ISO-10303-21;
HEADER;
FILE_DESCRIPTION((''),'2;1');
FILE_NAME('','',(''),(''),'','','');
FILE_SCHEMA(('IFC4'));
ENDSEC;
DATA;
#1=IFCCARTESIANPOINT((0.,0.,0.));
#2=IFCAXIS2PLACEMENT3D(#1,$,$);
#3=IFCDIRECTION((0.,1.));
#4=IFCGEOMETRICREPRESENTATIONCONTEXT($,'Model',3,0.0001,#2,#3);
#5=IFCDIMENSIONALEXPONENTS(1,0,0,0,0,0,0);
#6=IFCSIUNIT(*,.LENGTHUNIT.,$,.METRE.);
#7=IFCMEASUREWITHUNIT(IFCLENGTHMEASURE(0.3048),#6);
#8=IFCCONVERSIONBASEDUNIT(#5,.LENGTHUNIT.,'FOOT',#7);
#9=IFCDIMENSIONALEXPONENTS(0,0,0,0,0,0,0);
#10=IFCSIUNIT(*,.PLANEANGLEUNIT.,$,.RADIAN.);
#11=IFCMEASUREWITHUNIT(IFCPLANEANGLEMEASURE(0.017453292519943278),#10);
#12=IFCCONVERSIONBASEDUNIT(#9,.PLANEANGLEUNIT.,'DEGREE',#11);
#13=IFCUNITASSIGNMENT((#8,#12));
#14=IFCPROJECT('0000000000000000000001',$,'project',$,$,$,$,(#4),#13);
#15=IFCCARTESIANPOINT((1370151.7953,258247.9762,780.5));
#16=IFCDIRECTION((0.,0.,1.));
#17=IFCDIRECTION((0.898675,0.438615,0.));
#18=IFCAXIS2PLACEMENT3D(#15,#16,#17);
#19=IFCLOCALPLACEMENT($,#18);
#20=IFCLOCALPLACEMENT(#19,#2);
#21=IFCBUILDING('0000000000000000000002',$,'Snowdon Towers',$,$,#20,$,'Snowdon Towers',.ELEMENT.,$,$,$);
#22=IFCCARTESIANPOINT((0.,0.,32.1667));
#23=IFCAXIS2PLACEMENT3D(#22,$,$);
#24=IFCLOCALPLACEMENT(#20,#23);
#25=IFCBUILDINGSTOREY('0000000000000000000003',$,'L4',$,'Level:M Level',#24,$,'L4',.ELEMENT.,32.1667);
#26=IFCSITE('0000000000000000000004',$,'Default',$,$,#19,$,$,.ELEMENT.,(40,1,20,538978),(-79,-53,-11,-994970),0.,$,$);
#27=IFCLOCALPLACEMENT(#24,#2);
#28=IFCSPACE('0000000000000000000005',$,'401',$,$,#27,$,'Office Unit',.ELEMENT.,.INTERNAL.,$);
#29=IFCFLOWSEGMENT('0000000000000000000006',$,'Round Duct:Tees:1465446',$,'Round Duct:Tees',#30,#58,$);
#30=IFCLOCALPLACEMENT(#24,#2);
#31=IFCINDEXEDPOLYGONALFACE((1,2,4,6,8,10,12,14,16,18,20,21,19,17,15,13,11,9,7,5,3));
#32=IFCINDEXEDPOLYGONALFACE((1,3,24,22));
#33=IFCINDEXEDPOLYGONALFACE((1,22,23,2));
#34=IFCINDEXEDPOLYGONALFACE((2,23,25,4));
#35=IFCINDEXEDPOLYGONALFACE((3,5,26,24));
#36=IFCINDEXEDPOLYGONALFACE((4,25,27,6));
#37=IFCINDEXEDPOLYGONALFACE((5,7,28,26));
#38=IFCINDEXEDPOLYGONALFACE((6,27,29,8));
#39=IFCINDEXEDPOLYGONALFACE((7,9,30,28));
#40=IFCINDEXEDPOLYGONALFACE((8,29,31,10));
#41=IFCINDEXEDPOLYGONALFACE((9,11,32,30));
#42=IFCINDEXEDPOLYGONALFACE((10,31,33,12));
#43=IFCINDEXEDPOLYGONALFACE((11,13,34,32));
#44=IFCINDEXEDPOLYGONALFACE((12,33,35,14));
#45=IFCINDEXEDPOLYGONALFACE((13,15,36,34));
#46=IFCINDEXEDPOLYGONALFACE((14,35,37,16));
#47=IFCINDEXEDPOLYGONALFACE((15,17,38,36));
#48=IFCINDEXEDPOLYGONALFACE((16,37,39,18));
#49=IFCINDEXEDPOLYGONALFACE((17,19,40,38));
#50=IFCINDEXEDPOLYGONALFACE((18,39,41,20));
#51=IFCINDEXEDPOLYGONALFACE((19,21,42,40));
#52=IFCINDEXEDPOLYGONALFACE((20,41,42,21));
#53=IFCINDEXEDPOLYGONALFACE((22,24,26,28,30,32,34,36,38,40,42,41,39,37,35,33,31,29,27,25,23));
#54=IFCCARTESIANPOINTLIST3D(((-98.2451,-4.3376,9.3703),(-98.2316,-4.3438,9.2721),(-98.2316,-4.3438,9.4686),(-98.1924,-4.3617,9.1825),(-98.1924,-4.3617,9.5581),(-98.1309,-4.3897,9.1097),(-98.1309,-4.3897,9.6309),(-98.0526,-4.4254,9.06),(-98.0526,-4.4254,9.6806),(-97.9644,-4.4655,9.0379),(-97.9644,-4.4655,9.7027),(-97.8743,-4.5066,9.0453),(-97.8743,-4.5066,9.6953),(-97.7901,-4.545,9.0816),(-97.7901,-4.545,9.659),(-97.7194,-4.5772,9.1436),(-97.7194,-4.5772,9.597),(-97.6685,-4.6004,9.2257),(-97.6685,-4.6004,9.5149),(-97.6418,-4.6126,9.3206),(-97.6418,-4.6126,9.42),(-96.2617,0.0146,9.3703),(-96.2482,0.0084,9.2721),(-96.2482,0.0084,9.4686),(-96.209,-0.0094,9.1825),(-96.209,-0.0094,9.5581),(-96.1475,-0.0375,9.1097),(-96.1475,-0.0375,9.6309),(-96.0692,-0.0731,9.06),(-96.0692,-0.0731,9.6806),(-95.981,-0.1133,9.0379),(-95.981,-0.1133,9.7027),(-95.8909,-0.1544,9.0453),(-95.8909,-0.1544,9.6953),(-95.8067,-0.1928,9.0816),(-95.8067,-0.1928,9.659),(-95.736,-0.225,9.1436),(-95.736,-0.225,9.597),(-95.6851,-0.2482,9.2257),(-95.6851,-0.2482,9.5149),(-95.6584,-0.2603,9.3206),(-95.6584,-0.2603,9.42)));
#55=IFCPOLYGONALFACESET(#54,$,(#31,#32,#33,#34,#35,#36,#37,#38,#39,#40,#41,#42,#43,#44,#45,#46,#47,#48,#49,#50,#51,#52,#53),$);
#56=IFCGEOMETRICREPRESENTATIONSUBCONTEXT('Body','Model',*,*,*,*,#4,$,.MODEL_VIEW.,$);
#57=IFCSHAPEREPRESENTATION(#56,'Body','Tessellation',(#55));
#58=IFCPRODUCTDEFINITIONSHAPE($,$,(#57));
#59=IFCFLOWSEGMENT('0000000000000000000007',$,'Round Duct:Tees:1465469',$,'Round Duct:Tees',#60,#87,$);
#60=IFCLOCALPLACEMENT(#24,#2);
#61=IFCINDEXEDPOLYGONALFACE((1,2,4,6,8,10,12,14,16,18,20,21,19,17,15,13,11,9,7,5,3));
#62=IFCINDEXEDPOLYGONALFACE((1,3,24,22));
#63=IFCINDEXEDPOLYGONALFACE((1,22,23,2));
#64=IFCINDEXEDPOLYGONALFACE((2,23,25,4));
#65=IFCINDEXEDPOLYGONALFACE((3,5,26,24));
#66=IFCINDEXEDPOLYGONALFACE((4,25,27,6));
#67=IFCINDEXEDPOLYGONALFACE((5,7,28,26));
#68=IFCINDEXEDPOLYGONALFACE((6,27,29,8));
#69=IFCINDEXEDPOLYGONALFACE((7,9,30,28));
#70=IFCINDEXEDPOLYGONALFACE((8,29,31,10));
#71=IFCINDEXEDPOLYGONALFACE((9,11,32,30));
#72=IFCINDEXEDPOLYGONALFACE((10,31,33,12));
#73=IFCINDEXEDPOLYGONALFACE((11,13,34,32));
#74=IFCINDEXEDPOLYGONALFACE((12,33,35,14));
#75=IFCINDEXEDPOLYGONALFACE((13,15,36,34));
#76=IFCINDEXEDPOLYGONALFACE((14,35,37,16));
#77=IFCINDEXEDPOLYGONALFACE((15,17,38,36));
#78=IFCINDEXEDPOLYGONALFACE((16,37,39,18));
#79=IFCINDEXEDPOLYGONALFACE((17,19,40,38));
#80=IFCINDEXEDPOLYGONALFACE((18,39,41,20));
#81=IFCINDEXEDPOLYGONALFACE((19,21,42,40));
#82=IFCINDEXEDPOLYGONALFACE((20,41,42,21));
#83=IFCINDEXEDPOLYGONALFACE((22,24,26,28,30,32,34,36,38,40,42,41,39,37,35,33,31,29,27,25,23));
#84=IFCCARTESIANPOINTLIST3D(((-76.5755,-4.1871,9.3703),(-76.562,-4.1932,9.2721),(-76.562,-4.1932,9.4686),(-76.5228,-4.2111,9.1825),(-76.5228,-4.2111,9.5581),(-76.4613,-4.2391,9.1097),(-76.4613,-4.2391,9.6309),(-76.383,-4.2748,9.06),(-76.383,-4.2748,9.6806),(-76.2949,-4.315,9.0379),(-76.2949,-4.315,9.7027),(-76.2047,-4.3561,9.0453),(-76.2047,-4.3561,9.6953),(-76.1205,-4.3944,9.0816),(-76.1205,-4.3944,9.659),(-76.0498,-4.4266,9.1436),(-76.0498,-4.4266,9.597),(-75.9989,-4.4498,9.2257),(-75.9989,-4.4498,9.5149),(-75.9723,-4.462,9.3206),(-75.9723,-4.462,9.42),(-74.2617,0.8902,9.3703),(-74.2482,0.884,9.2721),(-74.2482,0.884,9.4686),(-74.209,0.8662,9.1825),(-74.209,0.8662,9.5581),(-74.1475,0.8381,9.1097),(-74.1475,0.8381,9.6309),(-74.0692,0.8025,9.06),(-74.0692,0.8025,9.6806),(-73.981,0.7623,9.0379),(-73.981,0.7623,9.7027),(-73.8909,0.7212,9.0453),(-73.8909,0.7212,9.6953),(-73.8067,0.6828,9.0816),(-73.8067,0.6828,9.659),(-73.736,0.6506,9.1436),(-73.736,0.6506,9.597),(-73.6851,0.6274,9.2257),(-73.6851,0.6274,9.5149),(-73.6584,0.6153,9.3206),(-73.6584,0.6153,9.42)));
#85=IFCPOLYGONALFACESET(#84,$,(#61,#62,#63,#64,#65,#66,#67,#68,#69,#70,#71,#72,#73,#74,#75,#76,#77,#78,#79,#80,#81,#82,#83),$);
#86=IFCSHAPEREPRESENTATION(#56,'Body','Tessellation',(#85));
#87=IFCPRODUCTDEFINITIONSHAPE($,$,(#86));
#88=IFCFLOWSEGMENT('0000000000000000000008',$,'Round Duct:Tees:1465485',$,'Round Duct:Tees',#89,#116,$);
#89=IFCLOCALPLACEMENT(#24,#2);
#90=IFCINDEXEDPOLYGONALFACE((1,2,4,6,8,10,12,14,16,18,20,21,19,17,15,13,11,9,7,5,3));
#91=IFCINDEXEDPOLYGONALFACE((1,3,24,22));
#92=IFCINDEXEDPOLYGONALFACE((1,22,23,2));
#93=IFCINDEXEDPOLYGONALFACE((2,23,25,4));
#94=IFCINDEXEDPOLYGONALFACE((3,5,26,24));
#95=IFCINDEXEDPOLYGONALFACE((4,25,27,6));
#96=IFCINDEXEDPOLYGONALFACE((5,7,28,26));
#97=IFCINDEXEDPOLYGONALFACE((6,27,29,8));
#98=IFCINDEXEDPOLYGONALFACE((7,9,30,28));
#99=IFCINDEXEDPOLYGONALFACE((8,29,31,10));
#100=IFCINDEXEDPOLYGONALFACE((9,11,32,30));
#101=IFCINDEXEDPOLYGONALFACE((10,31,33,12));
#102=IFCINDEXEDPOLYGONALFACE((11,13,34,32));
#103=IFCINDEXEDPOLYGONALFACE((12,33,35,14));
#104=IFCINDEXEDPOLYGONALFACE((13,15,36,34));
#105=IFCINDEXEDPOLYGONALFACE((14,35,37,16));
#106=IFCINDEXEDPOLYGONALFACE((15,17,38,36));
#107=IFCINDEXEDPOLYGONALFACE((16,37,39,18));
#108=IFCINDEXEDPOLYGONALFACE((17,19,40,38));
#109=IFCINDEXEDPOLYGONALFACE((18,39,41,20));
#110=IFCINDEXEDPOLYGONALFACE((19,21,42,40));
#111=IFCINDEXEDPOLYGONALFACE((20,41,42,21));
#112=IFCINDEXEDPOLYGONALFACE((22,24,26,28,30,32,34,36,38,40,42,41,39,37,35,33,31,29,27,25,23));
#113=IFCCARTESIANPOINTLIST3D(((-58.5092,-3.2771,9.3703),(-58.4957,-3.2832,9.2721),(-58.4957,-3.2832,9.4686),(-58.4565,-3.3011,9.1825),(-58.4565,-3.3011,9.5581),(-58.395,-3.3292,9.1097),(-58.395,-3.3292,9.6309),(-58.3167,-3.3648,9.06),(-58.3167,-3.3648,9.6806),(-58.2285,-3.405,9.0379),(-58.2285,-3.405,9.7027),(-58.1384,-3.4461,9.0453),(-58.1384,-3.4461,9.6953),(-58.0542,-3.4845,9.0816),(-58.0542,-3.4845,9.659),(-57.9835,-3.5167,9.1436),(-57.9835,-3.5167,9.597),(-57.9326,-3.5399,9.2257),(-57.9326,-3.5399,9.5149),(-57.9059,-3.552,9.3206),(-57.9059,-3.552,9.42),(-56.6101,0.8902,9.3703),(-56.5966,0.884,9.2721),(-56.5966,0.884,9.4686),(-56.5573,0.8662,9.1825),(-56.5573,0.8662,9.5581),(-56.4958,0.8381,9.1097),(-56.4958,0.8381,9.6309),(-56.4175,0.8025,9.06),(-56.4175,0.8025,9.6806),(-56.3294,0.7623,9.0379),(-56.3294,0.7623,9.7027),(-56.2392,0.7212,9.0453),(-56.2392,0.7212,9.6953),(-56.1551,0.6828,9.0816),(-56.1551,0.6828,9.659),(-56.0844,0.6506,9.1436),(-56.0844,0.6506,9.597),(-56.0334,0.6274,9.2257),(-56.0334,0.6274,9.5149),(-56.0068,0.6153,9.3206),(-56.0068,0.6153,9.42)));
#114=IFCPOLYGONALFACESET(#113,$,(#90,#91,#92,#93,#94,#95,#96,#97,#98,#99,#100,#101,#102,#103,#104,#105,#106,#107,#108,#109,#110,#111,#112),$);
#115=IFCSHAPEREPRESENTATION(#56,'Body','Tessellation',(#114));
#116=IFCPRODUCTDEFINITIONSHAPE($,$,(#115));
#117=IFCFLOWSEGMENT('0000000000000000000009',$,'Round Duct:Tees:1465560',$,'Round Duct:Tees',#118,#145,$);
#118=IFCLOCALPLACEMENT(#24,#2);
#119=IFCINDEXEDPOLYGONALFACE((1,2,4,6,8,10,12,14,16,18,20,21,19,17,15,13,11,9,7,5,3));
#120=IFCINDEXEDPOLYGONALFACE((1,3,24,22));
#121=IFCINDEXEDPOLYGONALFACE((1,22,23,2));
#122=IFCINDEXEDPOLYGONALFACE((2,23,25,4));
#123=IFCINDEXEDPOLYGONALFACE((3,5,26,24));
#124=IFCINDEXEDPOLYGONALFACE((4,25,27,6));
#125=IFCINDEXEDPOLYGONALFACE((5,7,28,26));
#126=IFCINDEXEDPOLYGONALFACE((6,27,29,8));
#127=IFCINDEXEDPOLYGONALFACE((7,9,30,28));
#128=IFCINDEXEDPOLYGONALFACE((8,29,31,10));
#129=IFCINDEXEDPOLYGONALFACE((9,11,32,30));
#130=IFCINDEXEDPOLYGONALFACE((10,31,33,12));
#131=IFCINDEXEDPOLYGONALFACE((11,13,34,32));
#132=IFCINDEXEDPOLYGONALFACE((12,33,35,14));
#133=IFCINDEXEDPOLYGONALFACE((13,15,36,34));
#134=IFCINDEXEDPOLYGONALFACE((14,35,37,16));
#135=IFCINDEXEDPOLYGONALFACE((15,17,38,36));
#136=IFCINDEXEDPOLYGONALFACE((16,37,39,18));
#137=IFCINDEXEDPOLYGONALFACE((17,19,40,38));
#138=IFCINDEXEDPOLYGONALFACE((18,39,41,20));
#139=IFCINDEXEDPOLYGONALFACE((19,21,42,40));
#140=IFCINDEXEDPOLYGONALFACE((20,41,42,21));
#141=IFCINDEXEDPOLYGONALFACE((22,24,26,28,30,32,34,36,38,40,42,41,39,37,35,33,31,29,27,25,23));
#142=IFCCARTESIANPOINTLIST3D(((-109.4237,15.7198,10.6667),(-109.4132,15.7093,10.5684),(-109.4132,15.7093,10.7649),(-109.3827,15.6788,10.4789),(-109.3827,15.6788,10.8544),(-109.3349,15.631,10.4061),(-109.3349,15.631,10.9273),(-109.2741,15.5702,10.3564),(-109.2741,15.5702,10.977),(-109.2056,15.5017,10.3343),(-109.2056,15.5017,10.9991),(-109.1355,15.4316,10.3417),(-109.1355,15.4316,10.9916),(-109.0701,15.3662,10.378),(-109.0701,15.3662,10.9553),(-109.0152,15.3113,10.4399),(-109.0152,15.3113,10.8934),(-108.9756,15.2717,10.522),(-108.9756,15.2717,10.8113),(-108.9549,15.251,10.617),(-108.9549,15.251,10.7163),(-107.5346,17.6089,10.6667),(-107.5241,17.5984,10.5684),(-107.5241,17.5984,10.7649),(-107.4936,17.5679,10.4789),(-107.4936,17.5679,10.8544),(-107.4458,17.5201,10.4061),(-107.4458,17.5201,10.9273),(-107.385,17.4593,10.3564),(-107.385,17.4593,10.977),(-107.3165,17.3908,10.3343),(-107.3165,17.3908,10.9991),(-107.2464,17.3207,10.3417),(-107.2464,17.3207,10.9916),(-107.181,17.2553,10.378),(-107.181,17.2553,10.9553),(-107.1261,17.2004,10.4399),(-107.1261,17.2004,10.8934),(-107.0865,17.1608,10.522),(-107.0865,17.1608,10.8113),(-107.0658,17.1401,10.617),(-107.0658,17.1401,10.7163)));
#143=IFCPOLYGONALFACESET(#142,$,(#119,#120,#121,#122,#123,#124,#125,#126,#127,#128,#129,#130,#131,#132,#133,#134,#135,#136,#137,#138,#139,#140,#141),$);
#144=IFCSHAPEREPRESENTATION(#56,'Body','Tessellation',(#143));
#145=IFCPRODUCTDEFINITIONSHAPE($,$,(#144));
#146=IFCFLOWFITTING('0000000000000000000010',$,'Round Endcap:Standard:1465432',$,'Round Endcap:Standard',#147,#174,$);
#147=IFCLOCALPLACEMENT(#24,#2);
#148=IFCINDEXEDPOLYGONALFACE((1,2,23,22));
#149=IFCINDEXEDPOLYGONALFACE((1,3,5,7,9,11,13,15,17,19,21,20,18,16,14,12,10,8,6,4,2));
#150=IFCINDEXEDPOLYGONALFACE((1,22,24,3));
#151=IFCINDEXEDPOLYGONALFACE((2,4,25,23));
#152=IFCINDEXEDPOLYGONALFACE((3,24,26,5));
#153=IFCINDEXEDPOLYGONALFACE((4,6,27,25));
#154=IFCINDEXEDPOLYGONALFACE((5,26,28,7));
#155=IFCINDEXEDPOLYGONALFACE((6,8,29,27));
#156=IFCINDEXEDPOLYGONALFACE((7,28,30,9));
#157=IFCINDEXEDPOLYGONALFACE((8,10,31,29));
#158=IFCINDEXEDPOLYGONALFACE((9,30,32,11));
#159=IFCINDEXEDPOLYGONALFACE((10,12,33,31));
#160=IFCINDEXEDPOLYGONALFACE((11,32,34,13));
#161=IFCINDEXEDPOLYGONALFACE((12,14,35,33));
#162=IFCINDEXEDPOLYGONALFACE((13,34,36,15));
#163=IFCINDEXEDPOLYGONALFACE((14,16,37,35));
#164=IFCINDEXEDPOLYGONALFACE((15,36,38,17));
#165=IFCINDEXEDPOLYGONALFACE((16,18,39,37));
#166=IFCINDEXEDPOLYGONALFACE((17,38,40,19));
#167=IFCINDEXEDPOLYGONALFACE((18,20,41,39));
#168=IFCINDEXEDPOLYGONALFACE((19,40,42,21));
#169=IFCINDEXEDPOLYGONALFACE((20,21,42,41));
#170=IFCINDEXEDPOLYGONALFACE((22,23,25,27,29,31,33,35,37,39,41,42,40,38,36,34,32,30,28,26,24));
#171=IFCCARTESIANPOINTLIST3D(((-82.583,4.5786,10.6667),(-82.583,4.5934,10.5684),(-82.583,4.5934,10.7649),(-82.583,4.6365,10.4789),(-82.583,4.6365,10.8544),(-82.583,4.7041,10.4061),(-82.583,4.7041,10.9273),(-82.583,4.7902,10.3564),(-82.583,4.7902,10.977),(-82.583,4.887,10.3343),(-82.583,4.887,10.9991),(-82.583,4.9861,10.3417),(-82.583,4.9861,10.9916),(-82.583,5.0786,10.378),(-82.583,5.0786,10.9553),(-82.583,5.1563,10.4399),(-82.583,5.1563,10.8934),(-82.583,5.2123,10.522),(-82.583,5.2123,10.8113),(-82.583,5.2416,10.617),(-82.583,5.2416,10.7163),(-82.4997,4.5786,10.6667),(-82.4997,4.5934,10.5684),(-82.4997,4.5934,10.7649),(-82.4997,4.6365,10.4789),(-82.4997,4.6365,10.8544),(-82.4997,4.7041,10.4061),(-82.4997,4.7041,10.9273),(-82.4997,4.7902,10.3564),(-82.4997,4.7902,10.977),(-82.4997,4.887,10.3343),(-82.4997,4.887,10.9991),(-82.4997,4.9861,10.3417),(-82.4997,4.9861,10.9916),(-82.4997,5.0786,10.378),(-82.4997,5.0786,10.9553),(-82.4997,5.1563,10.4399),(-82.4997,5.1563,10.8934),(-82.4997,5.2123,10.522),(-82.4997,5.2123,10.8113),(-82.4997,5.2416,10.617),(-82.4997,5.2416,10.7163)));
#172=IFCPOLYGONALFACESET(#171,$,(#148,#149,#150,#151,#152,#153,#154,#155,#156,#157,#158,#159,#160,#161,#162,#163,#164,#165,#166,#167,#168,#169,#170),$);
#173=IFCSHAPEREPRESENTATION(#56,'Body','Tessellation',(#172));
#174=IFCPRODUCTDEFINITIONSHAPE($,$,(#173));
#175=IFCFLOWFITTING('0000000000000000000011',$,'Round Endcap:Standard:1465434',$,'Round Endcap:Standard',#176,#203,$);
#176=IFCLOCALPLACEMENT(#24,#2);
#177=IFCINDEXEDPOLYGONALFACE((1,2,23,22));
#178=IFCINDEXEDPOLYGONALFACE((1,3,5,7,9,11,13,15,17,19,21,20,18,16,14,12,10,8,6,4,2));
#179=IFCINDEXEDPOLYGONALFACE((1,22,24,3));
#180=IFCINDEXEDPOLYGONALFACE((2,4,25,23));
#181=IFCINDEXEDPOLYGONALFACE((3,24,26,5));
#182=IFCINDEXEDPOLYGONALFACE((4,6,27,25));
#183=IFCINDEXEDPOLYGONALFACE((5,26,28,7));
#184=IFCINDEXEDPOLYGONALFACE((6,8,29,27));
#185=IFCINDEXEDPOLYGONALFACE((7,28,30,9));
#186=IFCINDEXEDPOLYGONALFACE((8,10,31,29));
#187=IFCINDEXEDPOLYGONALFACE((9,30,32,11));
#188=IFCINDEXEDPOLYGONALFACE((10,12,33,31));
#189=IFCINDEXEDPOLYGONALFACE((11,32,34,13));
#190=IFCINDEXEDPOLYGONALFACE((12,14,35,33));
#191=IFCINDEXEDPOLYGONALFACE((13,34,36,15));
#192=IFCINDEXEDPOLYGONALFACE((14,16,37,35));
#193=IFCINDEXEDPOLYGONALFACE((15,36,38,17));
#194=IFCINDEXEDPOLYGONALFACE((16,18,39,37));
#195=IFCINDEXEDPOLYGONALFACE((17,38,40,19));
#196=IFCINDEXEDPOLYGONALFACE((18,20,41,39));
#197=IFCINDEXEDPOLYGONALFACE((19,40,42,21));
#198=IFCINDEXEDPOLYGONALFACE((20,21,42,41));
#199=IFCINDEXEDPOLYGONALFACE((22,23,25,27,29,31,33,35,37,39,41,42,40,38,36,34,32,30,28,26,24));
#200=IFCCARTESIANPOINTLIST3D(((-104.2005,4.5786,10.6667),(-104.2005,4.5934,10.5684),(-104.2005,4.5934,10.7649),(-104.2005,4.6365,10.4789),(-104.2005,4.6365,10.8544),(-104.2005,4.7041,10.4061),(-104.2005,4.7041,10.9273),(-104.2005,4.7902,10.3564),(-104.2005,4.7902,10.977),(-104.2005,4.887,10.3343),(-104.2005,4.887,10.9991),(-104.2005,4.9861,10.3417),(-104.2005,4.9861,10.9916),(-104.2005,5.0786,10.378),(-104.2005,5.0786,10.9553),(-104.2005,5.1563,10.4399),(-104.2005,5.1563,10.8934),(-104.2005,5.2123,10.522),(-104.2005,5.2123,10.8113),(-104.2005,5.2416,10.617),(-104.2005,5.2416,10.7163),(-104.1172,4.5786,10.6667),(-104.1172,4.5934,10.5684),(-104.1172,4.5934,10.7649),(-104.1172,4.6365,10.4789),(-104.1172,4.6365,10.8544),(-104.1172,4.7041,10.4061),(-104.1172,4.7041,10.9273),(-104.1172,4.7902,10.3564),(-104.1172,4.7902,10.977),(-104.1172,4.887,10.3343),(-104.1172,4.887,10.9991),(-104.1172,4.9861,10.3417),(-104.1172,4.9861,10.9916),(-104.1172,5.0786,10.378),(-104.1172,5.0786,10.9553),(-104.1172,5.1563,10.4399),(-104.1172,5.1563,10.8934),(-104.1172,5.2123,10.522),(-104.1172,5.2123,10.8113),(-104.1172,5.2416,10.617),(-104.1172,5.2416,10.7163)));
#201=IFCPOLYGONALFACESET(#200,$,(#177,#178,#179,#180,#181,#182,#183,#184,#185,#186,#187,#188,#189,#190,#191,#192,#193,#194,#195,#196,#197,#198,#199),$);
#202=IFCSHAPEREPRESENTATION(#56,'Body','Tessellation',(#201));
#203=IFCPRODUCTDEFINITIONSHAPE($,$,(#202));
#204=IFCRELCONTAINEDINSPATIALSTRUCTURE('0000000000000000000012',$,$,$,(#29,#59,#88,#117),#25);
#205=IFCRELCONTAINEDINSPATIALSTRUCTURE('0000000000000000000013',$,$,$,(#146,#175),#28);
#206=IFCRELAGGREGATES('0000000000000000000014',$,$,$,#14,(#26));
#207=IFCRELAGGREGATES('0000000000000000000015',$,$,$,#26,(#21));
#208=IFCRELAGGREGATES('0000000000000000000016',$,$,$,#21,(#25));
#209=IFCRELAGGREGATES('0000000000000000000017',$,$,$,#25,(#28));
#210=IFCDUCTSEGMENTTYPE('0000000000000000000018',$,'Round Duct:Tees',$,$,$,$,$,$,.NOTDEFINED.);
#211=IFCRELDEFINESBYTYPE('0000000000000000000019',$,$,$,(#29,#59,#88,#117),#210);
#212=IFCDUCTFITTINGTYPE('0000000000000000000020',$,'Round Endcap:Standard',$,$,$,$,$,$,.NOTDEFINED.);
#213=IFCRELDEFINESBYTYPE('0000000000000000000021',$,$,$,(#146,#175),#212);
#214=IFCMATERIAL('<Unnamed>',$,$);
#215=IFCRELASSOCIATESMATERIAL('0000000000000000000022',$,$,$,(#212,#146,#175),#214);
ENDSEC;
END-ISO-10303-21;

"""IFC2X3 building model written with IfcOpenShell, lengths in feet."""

from ifc_helpers import new_model, entity, si_unit, converted_unit, direction, frame, frame_2d, origin, origin_2d_with_axis, place, context, subcontext, project, spatial, circle, extrude, source, transform, mapped, material, type_object, type_shapes, element, save


model = new_model("IFC2X3")

# Units and contexts
model_context = context("Model", 3, precision=0.0001, world=origin(), true_north=direction((0.0, 1.0)))
body_context = subcontext(model_context, "Body", "Model", "MODEL_VIEW")
ifc_project = project(units=[converted_unit("LENGTHUNIT", "FOOT", entity("IfcLengthMeasure", 0.3048), si_unit("LENGTHUNIT", "METRE"), dimensions=[1, 0, 0, 0, 0, 0, 0]), converted_unit("PLANEANGLEUNIT", "DEGREE", entity("IfcPlaneAngleMeasure", 0.017453292519943278), si_unit("PLANEANGLEUNIT", "RADIAN"), dimensions=[0, 0, 0, 0, 0, 0, 0])], contexts=[model_context])

# Site, building, storey
site_placement = place(None, frame((1370151.7953, 258247.9762, 780.5), z_axis=(0.0, 0.0, 1.0), x_axis=(0.898675, 0.438615, 0.0)))
site = spatial("IfcSite", under=ifc_project, at=site_placement, Name="Default", CompositionType="ELEMENT", RefLatitude=(40, 1, 20, 538978), RefLongitude=(-79, -53, -11, -994970), RefElevation=0.0)
building_placement = place(site_placement, origin())
building = spatial("IfcBuilding", under=site, at=building_placement, Name="Snowdon Towers", LongName="Snowdon Towers", CompositionType="ELEMENT")
storey_placement = place(building_placement, frame((0.0, 0.0, 32.1667)))
storey = spatial("IfcBuildingStorey", under=building, at=storey_placement, Name="L4", ObjectType="Level:M Level", LongName="L4", CompositionType="ELEMENT", Elevation=32.1667)

# Flow segments
duct_segment_type = type_object("IfcDuctSegmentType", Name="Round Duct:Tees", PredefinedType="NOTDEFINED")
flow_segment_1_placement = place(storey_placement, frame((-98.2503, -4.6193, 9.7089)))
element("IfcFlowSegment", 1, at=flow_segment_1_placement, inside=storey, type_object=duct_segment_type, Name="Round Duct:Tees:1465446", ObjectType="Round Duct:Tees", context=body_context, shape_type="SweptSolid", body=[
    extrude(circle(Radius=0.3333, at=origin_2d_with_axis()), frame((0.3086, 0.1435, -0.3386), z_axis=(0.414693, 0.909961, 0.0), x_axis=(-0.909961, 0.414693, 0.0)), (0.0, 0.0, 1.0), 4.7829),
])
flow_segment_2_placement = place(storey_placement, frame((-76.5807, -4.4688, 9.7089)))
element("IfcFlowSegment", 2, at=flow_segment_2_placement, inside=storey, type_object=duct_segment_type, Name="Round Duct:Tees:1465469", ObjectType="Round Duct:Tees", context=body_context, shape_type="SweptSolid", body=[
    extrude(circle(Radius=0.3333, at=frame_2d((0.0, 0.0), x_axis=(1.0, 0.0))), frame((0.3086, 0.1435, -0.3386), z_axis=(0.414693, 0.909961, 0.0), x_axis=(-0.909961, 0.414693, 0.0)), (0.0, 0.0, 1.0), 5.5796),
])
flow_segment_3_placement = place(storey_placement, frame((-58.5144, -3.5588, 9.0317)))
element("IfcFlowSegment", 3, at=flow_segment_3_placement, inside=storey, type_object=duct_segment_type, Name="Round Duct:Tees:1465485", ObjectType="Round Duct:Tees", context=body_context, shape_type="SweptSolid", body=[
    extrude(circle(Radius=0.3333, at=origin_2d_with_axis()), frame((0.3086, 0.1435, 0.3386), z_axis=(0.414693, 0.909961, 0.0), x_axis=(-0.909961, 0.414693, 0.0)), (0.0, 0.0, 1.0), 4.5796),
])
flow_segment_4_placement = place(storey_placement, frame((-109.4289, 15.2431, 10.3281)))
element("IfcFlowSegment", 4, at=flow_segment_4_placement, inside=storey, type_object=duct_segment_type, Name="Round Duct:Tees:1465560", ObjectType="Round Duct:Tees", context=body_context, shape_type="SweptSolid", body=[
    extrude(circle(Radius=0.3333, at=frame_2d((0.0, 0.0), x_axis=(1.0, 0.0))), frame((0.2409, 0.2409, 0.3386), z_axis=(0.707107, 0.707107, 0.0), x_axis=(-0.707107, 0.707107, 0.0)), (0.0, 0.0, 1.0), 2.6716),
])

# Shared definitions
space_placement = place(storey_placement, origin())
space = spatial("IfcSpace", under=storey, at=space_placement, Name="401", LongName="Office Unit", CompositionType="ELEMENT", InteriorOrExteriorSpace="INTERNAL")

# Flow fittings
ifc_material = material(Name="<Unnamed>")
duct_fitting_type = type_object("IfcDuctFittingType", Name="Round Endcap:Standard", PredefinedType="NOTDEFINED", material=ifc_material)
shared_shape = source(origin(), body_context, "Body", "SweptSolid", [
    extrude(circle(Radius=0.3333, at=frame_2d((0.0, 0.0), x_axis=(1.0, 0.0))), frame((0.0, 0.0, 0.0), z_axis=(1.0, 0.0, 0.0), x_axis=(0.0, 1.0, 0.0)), (0.0, 0.0, 1.0), 0.0833),
])
type_shapes(duct_fitting_type, [shared_shape])
for number, where, z_axis, x_axis, name in (
    (5, (-82.4997, 4.912, 10.6667), (0.0, 0.0, 1.0), (-1.0, 0.0, 0.0), "Round Endcap:Standard:1465432"),
    (6, (-104.1172, 4.912, 10.6667), (0.0, 0.0, 1.0), (-1.0, 0.0, 0.0), "Round Endcap:Standard:1465434"),
):
    element("IfcFlowFitting", number, at=place(space_placement, frame(where, z_axis=z_axis, x_axis=x_axis)), inside=space, type_object=duct_fitting_type, material=ifc_material, Name=name, ObjectType="Round Endcap:Standard", context=body_context, shape_type="MappedRepresentation", body=[
        mapped(shared_shape, transform((0.0, 0.0, 0.0), scale=1.0)),
    ])

save(model, "model.ifc")
